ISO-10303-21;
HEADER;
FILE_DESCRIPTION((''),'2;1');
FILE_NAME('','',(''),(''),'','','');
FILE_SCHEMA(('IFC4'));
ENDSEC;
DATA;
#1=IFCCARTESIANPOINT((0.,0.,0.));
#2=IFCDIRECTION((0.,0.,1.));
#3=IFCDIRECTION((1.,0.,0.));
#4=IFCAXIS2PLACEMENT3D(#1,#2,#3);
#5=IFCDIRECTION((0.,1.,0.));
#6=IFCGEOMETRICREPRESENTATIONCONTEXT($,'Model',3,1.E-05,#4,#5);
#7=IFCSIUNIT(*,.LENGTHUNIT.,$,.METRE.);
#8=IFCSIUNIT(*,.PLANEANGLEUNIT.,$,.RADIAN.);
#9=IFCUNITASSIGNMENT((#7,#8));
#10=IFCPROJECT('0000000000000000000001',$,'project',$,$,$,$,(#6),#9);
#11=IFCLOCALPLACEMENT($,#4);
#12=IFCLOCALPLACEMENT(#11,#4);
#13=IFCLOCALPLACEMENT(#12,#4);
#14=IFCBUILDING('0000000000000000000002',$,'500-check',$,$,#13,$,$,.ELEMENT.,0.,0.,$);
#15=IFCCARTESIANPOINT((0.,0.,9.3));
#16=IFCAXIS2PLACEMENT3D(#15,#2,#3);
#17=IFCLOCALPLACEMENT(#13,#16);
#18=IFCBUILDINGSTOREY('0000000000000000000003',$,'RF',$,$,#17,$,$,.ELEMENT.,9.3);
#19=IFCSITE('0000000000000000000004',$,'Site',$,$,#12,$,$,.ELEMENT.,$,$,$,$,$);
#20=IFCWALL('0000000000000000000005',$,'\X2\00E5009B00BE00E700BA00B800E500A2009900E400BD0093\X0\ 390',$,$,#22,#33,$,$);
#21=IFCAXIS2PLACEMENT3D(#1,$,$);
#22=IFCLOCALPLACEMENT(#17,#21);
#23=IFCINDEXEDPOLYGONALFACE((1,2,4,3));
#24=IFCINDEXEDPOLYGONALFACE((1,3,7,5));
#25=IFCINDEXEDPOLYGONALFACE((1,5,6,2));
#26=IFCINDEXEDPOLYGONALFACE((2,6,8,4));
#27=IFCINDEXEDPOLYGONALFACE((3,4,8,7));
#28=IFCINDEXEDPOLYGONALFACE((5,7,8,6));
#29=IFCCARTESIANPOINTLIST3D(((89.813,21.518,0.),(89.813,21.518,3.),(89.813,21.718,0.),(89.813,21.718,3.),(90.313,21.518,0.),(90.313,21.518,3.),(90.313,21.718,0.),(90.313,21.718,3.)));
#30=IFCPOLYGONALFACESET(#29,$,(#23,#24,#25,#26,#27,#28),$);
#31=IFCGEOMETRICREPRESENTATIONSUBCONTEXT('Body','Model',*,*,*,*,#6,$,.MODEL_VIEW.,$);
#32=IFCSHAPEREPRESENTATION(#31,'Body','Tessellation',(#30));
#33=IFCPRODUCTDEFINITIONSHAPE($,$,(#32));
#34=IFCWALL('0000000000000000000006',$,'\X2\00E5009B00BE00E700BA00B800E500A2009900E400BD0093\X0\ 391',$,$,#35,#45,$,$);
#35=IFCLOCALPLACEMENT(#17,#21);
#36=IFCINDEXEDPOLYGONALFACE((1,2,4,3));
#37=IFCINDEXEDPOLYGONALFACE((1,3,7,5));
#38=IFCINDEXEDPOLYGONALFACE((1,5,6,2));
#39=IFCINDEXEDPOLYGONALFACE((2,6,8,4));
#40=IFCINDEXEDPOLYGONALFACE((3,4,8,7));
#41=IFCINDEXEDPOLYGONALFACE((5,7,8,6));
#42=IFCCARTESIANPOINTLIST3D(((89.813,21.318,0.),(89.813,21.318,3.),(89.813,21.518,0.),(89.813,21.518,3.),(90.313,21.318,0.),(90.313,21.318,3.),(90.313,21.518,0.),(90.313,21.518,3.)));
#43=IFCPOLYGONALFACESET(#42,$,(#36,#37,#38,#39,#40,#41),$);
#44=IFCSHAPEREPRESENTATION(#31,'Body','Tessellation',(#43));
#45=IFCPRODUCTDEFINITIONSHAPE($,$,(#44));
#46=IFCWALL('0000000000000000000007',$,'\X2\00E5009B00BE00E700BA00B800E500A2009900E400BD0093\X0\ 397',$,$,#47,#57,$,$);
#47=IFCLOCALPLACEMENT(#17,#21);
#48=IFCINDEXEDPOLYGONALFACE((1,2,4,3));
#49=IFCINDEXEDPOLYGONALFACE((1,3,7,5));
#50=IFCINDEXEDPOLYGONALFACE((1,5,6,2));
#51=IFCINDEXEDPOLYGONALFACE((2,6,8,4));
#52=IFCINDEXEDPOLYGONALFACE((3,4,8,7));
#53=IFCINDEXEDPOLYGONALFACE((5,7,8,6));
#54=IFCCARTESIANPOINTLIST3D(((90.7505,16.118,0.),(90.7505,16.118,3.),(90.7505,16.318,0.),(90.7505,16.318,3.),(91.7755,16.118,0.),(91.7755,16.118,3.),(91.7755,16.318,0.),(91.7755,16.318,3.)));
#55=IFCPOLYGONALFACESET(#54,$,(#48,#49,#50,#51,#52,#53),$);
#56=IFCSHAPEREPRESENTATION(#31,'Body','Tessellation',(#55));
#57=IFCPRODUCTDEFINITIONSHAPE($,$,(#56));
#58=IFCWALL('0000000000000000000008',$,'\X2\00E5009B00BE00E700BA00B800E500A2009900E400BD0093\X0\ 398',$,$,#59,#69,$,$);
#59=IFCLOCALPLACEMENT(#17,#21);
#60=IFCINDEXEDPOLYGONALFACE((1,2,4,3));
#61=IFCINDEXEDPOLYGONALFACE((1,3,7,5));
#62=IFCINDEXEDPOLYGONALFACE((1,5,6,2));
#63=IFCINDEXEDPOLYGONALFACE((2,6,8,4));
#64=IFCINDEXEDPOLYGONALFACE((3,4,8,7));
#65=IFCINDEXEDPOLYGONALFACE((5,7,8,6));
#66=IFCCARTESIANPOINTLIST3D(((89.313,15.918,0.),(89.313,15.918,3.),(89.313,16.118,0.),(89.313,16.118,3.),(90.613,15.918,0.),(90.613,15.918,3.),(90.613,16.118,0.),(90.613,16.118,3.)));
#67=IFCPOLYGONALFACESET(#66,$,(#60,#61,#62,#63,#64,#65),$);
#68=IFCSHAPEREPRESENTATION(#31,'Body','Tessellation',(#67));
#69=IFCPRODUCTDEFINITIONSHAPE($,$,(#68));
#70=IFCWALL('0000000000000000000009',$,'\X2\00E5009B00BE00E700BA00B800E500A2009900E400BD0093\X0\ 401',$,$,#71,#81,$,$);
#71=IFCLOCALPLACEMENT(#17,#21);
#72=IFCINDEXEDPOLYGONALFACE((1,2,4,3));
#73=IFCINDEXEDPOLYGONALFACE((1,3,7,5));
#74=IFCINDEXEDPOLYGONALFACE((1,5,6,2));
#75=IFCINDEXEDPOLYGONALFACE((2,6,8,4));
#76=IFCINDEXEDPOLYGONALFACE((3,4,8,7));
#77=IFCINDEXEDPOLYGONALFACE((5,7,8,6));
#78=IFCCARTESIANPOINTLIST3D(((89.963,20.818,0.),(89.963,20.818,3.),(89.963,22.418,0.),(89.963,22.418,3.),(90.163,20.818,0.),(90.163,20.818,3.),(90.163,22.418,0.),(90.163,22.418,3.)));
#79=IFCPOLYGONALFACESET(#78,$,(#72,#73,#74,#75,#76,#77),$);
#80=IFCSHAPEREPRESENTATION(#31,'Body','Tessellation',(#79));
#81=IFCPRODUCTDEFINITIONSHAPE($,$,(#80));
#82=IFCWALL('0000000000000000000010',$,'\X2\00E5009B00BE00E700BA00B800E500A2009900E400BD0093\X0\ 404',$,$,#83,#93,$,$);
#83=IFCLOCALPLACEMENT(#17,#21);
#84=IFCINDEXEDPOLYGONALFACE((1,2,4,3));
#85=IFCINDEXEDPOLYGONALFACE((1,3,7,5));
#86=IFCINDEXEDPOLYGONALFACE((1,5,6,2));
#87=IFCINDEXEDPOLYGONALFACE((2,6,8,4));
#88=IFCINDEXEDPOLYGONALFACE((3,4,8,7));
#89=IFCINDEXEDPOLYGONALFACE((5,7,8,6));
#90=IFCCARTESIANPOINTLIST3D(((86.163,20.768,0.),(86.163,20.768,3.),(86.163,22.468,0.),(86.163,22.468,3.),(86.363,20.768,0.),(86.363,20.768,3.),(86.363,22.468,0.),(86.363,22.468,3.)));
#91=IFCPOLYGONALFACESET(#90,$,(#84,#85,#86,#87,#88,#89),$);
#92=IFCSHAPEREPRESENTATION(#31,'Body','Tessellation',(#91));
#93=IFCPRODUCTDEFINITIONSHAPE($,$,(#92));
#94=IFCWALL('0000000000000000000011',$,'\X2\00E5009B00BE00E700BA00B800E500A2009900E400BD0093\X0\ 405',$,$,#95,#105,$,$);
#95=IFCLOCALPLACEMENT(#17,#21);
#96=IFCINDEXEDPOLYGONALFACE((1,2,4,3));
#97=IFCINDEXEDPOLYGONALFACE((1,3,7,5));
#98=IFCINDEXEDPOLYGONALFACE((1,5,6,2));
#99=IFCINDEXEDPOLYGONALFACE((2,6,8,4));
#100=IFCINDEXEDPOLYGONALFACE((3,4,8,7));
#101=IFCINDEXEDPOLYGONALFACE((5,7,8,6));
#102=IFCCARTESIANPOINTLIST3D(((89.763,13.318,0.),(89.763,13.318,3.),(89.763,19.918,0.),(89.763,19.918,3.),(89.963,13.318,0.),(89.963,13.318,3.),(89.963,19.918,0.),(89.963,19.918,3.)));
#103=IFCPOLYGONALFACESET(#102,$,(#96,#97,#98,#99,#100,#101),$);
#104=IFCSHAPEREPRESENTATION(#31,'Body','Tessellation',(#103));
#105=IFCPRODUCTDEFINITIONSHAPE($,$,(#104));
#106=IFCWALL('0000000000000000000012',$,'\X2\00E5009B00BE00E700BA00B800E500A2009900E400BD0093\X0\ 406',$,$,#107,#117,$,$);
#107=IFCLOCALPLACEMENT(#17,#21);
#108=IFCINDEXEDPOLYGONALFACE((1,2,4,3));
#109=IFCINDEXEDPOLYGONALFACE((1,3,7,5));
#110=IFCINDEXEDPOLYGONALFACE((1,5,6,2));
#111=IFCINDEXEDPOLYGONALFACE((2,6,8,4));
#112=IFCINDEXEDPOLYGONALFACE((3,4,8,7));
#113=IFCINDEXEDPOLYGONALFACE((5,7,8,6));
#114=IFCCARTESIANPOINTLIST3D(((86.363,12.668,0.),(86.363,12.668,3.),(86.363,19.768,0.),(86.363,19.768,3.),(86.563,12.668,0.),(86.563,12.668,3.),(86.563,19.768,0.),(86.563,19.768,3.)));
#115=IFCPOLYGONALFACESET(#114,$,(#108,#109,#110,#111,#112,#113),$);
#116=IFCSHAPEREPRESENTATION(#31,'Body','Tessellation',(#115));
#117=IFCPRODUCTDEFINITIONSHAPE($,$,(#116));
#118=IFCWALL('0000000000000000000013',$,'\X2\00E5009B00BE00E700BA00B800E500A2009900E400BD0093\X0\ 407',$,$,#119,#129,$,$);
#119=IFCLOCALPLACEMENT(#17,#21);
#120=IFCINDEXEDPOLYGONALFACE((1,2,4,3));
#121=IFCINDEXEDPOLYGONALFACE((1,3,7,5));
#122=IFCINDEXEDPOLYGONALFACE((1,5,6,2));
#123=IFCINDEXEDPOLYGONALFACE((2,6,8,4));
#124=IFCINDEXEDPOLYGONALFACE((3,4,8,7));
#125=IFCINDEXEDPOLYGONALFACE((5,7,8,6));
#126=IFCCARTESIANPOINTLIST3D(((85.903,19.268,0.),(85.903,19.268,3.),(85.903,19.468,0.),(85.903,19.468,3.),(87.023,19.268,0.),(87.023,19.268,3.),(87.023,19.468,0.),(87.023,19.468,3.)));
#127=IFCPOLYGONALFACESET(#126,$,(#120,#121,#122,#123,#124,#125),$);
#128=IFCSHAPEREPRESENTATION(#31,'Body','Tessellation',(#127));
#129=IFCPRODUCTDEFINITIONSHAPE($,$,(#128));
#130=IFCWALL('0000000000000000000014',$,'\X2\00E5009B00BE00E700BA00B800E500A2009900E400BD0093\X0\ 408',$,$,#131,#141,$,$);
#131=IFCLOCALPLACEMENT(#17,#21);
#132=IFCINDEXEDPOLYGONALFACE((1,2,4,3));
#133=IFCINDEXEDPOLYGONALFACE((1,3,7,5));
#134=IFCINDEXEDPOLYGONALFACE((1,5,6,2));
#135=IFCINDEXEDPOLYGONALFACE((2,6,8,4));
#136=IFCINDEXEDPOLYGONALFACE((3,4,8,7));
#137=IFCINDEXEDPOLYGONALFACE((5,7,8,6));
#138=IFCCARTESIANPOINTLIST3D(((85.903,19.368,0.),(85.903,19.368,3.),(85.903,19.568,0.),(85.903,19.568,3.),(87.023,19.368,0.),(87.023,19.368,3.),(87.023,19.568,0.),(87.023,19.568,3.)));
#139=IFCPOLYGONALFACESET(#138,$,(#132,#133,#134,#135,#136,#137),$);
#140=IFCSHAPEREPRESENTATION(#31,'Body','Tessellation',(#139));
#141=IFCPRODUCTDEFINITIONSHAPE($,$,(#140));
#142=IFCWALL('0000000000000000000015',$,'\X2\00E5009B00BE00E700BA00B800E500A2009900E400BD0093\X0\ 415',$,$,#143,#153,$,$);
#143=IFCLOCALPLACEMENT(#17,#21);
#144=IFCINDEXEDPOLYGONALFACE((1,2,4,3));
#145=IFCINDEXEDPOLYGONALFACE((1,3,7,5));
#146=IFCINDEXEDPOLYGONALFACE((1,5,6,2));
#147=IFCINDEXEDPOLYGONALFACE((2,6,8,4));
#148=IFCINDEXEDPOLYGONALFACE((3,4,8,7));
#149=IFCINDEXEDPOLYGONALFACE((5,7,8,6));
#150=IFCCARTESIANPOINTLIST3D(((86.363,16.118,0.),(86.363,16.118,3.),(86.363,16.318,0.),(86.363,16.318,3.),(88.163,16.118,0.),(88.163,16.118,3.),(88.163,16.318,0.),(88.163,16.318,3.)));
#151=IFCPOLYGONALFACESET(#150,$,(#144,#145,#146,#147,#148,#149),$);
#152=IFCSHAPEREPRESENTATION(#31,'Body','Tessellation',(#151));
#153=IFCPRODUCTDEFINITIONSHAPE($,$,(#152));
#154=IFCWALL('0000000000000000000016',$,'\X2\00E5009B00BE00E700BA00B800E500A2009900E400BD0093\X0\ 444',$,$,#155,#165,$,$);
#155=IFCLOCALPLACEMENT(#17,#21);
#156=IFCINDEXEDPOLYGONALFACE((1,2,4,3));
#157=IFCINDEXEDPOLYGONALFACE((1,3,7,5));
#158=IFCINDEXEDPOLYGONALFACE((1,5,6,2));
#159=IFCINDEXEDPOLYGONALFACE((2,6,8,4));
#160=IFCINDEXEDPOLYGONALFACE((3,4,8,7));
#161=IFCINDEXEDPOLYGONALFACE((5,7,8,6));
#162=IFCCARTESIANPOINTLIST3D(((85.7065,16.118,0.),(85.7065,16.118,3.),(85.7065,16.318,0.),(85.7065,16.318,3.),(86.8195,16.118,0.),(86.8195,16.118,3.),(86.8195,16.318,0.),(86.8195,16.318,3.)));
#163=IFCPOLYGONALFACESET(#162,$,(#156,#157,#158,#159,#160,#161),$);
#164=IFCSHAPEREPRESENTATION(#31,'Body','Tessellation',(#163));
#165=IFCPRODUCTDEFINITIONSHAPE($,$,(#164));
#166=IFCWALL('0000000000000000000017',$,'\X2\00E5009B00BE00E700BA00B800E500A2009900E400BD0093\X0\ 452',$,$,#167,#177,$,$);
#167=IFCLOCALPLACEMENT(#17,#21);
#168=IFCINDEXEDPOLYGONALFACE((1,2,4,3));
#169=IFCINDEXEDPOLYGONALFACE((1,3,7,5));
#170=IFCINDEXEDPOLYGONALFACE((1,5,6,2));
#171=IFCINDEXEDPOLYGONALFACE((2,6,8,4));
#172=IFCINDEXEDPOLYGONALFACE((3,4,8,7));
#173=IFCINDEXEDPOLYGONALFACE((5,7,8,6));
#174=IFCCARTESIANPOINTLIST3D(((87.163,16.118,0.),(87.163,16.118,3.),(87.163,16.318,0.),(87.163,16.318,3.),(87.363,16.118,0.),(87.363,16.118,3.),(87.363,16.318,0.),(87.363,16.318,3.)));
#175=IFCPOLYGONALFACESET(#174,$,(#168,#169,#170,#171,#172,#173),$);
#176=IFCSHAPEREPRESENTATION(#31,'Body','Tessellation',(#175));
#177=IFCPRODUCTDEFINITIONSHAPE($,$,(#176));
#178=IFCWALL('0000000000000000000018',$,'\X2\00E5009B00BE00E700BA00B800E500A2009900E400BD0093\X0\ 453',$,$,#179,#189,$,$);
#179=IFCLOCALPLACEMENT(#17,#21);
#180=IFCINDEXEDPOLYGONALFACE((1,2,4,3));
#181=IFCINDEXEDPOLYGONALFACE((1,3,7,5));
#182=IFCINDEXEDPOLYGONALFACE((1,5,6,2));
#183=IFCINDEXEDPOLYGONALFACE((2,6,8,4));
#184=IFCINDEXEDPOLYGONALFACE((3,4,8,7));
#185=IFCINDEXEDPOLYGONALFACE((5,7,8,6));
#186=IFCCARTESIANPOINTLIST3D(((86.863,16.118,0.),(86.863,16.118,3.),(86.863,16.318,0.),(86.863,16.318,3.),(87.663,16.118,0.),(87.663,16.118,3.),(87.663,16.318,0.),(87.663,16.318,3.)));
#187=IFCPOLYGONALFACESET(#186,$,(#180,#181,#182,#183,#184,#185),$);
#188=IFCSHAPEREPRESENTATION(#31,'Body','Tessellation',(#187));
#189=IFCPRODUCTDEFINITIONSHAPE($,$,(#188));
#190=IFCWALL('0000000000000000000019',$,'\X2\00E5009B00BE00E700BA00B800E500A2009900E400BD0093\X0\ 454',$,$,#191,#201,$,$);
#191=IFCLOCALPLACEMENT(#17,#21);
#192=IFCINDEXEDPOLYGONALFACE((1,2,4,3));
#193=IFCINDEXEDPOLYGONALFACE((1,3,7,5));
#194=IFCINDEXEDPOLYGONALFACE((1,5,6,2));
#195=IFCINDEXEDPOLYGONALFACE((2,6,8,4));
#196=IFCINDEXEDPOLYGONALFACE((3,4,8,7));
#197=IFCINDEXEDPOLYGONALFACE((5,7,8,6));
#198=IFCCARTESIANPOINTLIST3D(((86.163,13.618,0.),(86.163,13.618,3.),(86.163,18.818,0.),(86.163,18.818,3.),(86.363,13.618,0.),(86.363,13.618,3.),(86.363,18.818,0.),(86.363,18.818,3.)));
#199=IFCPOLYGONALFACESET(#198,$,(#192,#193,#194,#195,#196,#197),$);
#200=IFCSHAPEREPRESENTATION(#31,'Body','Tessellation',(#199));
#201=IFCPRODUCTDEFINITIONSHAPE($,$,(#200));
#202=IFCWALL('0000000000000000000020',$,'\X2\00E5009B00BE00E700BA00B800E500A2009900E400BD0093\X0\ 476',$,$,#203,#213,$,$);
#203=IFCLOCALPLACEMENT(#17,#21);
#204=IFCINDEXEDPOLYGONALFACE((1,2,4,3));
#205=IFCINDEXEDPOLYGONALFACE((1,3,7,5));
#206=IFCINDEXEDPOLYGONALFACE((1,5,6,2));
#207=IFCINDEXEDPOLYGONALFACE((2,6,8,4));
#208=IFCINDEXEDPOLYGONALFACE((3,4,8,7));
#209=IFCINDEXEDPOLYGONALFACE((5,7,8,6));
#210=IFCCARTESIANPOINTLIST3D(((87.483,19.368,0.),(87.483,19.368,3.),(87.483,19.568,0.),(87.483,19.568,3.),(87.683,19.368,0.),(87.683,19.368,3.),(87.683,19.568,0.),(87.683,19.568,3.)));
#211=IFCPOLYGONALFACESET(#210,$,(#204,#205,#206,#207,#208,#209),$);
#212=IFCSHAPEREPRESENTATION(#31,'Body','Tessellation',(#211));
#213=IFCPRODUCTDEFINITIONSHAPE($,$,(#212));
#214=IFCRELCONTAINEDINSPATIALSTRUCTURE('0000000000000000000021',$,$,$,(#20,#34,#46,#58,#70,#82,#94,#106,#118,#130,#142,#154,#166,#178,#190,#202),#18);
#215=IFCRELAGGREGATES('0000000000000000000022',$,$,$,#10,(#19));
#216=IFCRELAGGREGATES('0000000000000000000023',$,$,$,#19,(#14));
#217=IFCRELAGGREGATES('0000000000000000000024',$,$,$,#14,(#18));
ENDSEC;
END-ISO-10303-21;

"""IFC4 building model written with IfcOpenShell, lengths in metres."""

from ifc_helpers import new_model, si_unit, direction, frame, frame_2d, origin_with_axes, place, context, subcontext, project, spatial, rectangle, extrude, element, save


model = new_model("IFC4")

# Units and contexts
model_context = context("Model", 3, precision=1e-05, world=origin_with_axes(), true_north=direction((0.0, 1.0, 0.0)))
body_context = subcontext(model_context, "Body", "Model", "MODEL_VIEW")
ifc_project = project(units=[si_unit("LENGTHUNIT", "METRE"), si_unit("PLANEANGLEUNIT", "RADIAN")], contexts=[model_context])

# Site, building, storey
placement = place(None, origin_with_axes())
site_placement = place(placement, origin_with_axes())
site = spatial("IfcSite", under=ifc_project, at=site_placement, Name="Site", CompositionType="ELEMENT")
building_placement = place(site_placement, origin_with_axes())
building = spatial("IfcBuilding", under=site, at=building_placement, Name="500-check", CompositionType="ELEMENT", ElevationOfRefHeight=0.0, ElevationOfTerrain=0.0)
storey_placement = place(building_placement, frame((0.0, 0.0, 9.3), z_axis=(0.0, 0.0, 1.0), x_axis=(1.0, 0.0, 0.0)))
storey = spatial("IfcBuildingStorey", under=building, at=storey_placement, Name="RF", CompositionType="ELEMENT", Elevation=9.3)

# Walls
for number, where, z_axis, x_axis, name in (
    (1, (90.063, 21.618, 0.0), (0.0, 0.0, 1.0), (1.0, 0.0, 0.0), "å\u009b¾çº¸å¢\u0099ä½\u0093 390"),
    (2, (90.063, 21.418, 0.0), (0.0, 0.0, 1.0), (1.0, 0.0, 0.0), "å\u009b¾çº¸å¢\u0099ä½\u0093 391"),
):
    element("IfcWall", number, at=place(storey_placement, frame(where, z_axis=z_axis, x_axis=x_axis)), inside=storey, Name=name, context=body_context, shape_type="SweptSolid", body=[
        extrude(rectangle(XDim=0.5, YDim=0.2, at=frame_2d((0.0, 0.0), x_axis=(1.0, 0.0, 0.0))), frame((0.0, 0.0, 0.0), z_axis=(0.0, 0.0, 1.0)), (0.0, 0.0, 1.0), 3.0),
    ])
wall_1_placement = place(storey_placement, frame((91.263, 16.218, 0.0), z_axis=(0.0, 0.0, 1.0), x_axis=(-1.0, 0.0, 0.0)))
element("IfcWall", 3, at=wall_1_placement, inside=storey, Name="å\u009b¾çº¸å¢\u0099ä½\u0093 397", context=body_context, shape_type="SweptSolid", body=[
    extrude(rectangle(XDim=1.025, YDim=0.2, at=frame_2d((0.0, 0.0), x_axis=(1.0, 0.0, 0.0))), frame((0.0, 0.0, 0.0), z_axis=(0.0, 0.0, 1.0)), (0.0, 0.0, 1.0), 3.0),
])
wall_2_placement = place(storey_placement, frame((89.963, 16.018, 0.0), z_axis=(0.0, 0.0, 1.0), x_axis=(1.0, 0.0, 0.0)))
element("IfcWall", 4, at=wall_2_placement, inside=storey, Name="å\u009b¾çº¸å¢\u0099ä½\u0093 398", context=body_context, shape_type="SweptSolid", body=[
    extrude(rectangle(XDim=1.3, YDim=0.2, at=frame_2d((0.0, 0.0), x_axis=(1.0, 0.0, 0.0))), frame((0.0, 0.0, 0.0), z_axis=(0.0, 0.0, 1.0)), (0.0, 0.0, 1.0), 3.0),
])
wall_3_placement = place(storey_placement, frame((90.063, 21.618, 0.0), z_axis=(0.0, 0.0, 1.0), x_axis=(0.0, 1.0, 0.0)))
element("IfcWall", 5, at=wall_3_placement, inside=storey, Name="å\u009b¾çº¸å¢\u0099ä½\u0093 401", context=body_context, shape_type="SweptSolid", body=[
    extrude(rectangle(XDim=1.6, YDim=0.2, at=frame_2d((0.0, 0.0), x_axis=(1.0, 0.0, 0.0))), frame((0.0, 0.0, 0.0), z_axis=(0.0, 0.0, 1.0)), (0.0, 0.0, 1.0), 3.0),
])
wall_4_placement = place(storey_placement, frame((86.263, 21.618, 0.0), z_axis=(0.0, 0.0, 1.0), x_axis=(0.0, 1.0, 0.0)))
element("IfcWall", 6, at=wall_4_placement, inside=storey, Name="å\u009b¾çº¸å¢\u0099ä½\u0093 404", context=body_context, shape_type="SweptSolid", body=[
    extrude(rectangle(XDim=1.7, YDim=0.2, at=frame_2d((0.0, 0.0), x_axis=(1.0, 0.0, 0.0))), frame((0.0, 0.0, 0.0), z_axis=(0.0, 0.0, 1.0)), (0.0, 0.0, 1.0), 3.0),
])
wall_5_placement = place(storey_placement, frame((89.863, 16.618, 0.0), z_axis=(0.0, 0.0, 1.0), x_axis=(0.0, 1.0, 0.0)))
element("IfcWall", 7, at=wall_5_placement, inside=storey, Name="å\u009b¾çº¸å¢\u0099ä½\u0093 405", context=body_context, shape_type="SweptSolid", body=[
    extrude(rectangle(XDim=6.6, YDim=0.2, at=frame_2d((0.0, 0.0), x_axis=(1.0, 0.0, 0.0))), frame((0.0, 0.0, 0.0), z_axis=(0.0, 0.0, 1.0)), (0.0, 0.0, 1.0), 3.0),
])
wall_6_placement = place(storey_placement, frame((86.463, 16.218, 0.0), z_axis=(0.0, 0.0, 1.0), x_axis=(0.0, 1.0, 0.0)))
element("IfcWall", 8, at=wall_6_placement, inside=storey, Name="å\u009b¾çº¸å¢\u0099ä½\u0093 406", context=body_context, shape_type="SweptSolid", body=[
    extrude(rectangle(XDim=7.1, YDim=0.2, at=frame_2d((0.0, 0.0), x_axis=(1.0, 0.0, 0.0))), frame((0.0, 0.0, 0.0), z_axis=(0.0, 0.0, 1.0)), (0.0, 0.0, 1.0), 3.0),
])
for number, where, z_axis, x_axis, name in (
    (9, (86.463, 19.368, 0.0), (0.0, 0.0, 1.0), (1.0, 0.0, 0.0), "å\u009b¾çº¸å¢\u0099ä½\u0093 407"),
    (10, (86.463, 19.468, 0.0), (0.0, 0.0, 1.0), (1.0, 0.0, 0.0), "å\u009b¾çº¸å¢\u0099ä½\u0093 408"),
):
    element("IfcWall", number, at=place(storey_placement, frame(where, z_axis=z_axis, x_axis=x_axis)), inside=storey, Name=name, context=body_context, shape_type="SweptSolid", body=[
        extrude(rectangle(XDim=1.12, YDim=0.2, at=frame_2d((0.0, 0.0), x_axis=(1.0, 0.0, 0.0))), frame((0.0, 0.0, 0.0), z_axis=(0.0, 0.0, 1.0)), (0.0, 0.0, 1.0), 3.0),
    ])
wall_7_placement = place(storey_placement, frame((87.263, 16.218, 0.0), z_axis=(0.0, 0.0, 1.0), x_axis=(1.0, 0.0, 0.0)))
element("IfcWall", 11, at=wall_7_placement, inside=storey, Name="å\u009b¾çº¸å¢\u0099ä½\u0093 415", context=body_context, shape_type="SweptSolid", body=[
    extrude(rectangle(XDim=1.8, YDim=0.2, at=frame_2d((0.0, 0.0), x_axis=(1.0, 0.0, 0.0))), frame((0.0, 0.0, 0.0), z_axis=(0.0, 0.0, 1.0)), (0.0, 0.0, 1.0), 3.0),
])
wall_8_placement = place(storey_placement, frame((86.263, 16.218, 0.0), z_axis=(0.0, 0.0, 1.0), x_axis=(-1.0, 0.0, 0.0)))
element("IfcWall", 12, at=wall_8_placement, inside=storey, Name="å\u009b¾çº¸å¢\u0099ä½\u0093 444", context=body_context, shape_type="SweptSolid", body=[
    extrude(rectangle(XDim=1.113, YDim=0.2, at=frame_2d((0.0, 0.0), x_axis=(1.0, 0.0, 0.0))), frame((0.0, 0.0, 0.0), z_axis=(0.0, 0.0, 1.0)), (0.0, 0.0, 1.0), 3.0),
])
wall_9_placement = place(storey_placement, frame((87.263, 16.218, 0.0), z_axis=(0.0, 0.0, 1.0), x_axis=(0.0, -1.0, 0.0)))
element("IfcWall", 13, at=wall_9_placement, inside=storey, Name="å\u009b¾çº¸å¢\u0099ä½\u0093 452", context=body_context, shape_type="SweptSolid", body=[
    extrude(rectangle(XDim=0.2, YDim=0.2, at=frame_2d((0.0, 0.0), x_axis=(1.0, 0.0, 0.0))), frame((0.0, 0.0, 0.0), z_axis=(0.0, 0.0, 1.0)), (0.0, 0.0, 1.0), 3.0),
])
wall_10_placement = place(storey_placement, frame((87.263, 16.218, 0.0), z_axis=(0.0, 0.0, 1.0), x_axis=(-1.0, 0.0, 0.0)))
element("IfcWall", 14, at=wall_10_placement, inside=storey, Name="å\u009b¾çº¸å¢\u0099ä½\u0093 453", context=body_context, shape_type="SweptSolid", body=[
    extrude(rectangle(XDim=0.8, YDim=0.2, at=frame_2d((0.0, 0.0), x_axis=(1.0, 0.0, 0.0))), frame((0.0, 0.0, 0.0), z_axis=(0.0, 0.0, 1.0)), (0.0, 0.0, 1.0), 3.0),
])
wall_11_placement = place(storey_placement, frame((86.263, 16.218, 0.0), z_axis=(0.0, 0.0, 1.0), x_axis=(0.0, 1.0, 0.0)))
element("IfcWall", 15, at=wall_11_placement, inside=storey, Name="å\u009b¾çº¸å¢\u0099ä½\u0093 454", context=body_context, shape_type="SweptSolid", body=[
    extrude(rectangle(XDim=5.2, YDim=0.2, at=frame_2d((0.0, 0.0), x_axis=(1.0, 0.0, 0.0))), frame((0.0, 0.0, 0.0), z_axis=(0.0, 0.0, 1.0)), (0.0, 0.0, 1.0), 3.0),
])
for number, where, z_axis, x_axis, name in (
    (16, (87.583, 19.468, 0.0), (0.0, 0.0, 1.0), (0.0, -1.0, 0.0), "å\u009b¾çº¸å¢\u0099ä½\u0093 476"),
):
    element("IfcWall", number, at=place(storey_placement, frame(where, z_axis=z_axis, x_axis=x_axis)), inside=storey, Name=name, context=body_context, shape_type="SweptSolid", body=[
        extrude(rectangle(XDim=0.2, YDim=0.2, at=frame_2d((0.0, 0.0), x_axis=(1.0, 0.0, 0.0))), frame((0.0, 0.0, 0.0), z_axis=(0.0, 0.0, 1.0)), (0.0, 0.0, 1.0), 3.0),
    ])

save(model, "model.ifc")
